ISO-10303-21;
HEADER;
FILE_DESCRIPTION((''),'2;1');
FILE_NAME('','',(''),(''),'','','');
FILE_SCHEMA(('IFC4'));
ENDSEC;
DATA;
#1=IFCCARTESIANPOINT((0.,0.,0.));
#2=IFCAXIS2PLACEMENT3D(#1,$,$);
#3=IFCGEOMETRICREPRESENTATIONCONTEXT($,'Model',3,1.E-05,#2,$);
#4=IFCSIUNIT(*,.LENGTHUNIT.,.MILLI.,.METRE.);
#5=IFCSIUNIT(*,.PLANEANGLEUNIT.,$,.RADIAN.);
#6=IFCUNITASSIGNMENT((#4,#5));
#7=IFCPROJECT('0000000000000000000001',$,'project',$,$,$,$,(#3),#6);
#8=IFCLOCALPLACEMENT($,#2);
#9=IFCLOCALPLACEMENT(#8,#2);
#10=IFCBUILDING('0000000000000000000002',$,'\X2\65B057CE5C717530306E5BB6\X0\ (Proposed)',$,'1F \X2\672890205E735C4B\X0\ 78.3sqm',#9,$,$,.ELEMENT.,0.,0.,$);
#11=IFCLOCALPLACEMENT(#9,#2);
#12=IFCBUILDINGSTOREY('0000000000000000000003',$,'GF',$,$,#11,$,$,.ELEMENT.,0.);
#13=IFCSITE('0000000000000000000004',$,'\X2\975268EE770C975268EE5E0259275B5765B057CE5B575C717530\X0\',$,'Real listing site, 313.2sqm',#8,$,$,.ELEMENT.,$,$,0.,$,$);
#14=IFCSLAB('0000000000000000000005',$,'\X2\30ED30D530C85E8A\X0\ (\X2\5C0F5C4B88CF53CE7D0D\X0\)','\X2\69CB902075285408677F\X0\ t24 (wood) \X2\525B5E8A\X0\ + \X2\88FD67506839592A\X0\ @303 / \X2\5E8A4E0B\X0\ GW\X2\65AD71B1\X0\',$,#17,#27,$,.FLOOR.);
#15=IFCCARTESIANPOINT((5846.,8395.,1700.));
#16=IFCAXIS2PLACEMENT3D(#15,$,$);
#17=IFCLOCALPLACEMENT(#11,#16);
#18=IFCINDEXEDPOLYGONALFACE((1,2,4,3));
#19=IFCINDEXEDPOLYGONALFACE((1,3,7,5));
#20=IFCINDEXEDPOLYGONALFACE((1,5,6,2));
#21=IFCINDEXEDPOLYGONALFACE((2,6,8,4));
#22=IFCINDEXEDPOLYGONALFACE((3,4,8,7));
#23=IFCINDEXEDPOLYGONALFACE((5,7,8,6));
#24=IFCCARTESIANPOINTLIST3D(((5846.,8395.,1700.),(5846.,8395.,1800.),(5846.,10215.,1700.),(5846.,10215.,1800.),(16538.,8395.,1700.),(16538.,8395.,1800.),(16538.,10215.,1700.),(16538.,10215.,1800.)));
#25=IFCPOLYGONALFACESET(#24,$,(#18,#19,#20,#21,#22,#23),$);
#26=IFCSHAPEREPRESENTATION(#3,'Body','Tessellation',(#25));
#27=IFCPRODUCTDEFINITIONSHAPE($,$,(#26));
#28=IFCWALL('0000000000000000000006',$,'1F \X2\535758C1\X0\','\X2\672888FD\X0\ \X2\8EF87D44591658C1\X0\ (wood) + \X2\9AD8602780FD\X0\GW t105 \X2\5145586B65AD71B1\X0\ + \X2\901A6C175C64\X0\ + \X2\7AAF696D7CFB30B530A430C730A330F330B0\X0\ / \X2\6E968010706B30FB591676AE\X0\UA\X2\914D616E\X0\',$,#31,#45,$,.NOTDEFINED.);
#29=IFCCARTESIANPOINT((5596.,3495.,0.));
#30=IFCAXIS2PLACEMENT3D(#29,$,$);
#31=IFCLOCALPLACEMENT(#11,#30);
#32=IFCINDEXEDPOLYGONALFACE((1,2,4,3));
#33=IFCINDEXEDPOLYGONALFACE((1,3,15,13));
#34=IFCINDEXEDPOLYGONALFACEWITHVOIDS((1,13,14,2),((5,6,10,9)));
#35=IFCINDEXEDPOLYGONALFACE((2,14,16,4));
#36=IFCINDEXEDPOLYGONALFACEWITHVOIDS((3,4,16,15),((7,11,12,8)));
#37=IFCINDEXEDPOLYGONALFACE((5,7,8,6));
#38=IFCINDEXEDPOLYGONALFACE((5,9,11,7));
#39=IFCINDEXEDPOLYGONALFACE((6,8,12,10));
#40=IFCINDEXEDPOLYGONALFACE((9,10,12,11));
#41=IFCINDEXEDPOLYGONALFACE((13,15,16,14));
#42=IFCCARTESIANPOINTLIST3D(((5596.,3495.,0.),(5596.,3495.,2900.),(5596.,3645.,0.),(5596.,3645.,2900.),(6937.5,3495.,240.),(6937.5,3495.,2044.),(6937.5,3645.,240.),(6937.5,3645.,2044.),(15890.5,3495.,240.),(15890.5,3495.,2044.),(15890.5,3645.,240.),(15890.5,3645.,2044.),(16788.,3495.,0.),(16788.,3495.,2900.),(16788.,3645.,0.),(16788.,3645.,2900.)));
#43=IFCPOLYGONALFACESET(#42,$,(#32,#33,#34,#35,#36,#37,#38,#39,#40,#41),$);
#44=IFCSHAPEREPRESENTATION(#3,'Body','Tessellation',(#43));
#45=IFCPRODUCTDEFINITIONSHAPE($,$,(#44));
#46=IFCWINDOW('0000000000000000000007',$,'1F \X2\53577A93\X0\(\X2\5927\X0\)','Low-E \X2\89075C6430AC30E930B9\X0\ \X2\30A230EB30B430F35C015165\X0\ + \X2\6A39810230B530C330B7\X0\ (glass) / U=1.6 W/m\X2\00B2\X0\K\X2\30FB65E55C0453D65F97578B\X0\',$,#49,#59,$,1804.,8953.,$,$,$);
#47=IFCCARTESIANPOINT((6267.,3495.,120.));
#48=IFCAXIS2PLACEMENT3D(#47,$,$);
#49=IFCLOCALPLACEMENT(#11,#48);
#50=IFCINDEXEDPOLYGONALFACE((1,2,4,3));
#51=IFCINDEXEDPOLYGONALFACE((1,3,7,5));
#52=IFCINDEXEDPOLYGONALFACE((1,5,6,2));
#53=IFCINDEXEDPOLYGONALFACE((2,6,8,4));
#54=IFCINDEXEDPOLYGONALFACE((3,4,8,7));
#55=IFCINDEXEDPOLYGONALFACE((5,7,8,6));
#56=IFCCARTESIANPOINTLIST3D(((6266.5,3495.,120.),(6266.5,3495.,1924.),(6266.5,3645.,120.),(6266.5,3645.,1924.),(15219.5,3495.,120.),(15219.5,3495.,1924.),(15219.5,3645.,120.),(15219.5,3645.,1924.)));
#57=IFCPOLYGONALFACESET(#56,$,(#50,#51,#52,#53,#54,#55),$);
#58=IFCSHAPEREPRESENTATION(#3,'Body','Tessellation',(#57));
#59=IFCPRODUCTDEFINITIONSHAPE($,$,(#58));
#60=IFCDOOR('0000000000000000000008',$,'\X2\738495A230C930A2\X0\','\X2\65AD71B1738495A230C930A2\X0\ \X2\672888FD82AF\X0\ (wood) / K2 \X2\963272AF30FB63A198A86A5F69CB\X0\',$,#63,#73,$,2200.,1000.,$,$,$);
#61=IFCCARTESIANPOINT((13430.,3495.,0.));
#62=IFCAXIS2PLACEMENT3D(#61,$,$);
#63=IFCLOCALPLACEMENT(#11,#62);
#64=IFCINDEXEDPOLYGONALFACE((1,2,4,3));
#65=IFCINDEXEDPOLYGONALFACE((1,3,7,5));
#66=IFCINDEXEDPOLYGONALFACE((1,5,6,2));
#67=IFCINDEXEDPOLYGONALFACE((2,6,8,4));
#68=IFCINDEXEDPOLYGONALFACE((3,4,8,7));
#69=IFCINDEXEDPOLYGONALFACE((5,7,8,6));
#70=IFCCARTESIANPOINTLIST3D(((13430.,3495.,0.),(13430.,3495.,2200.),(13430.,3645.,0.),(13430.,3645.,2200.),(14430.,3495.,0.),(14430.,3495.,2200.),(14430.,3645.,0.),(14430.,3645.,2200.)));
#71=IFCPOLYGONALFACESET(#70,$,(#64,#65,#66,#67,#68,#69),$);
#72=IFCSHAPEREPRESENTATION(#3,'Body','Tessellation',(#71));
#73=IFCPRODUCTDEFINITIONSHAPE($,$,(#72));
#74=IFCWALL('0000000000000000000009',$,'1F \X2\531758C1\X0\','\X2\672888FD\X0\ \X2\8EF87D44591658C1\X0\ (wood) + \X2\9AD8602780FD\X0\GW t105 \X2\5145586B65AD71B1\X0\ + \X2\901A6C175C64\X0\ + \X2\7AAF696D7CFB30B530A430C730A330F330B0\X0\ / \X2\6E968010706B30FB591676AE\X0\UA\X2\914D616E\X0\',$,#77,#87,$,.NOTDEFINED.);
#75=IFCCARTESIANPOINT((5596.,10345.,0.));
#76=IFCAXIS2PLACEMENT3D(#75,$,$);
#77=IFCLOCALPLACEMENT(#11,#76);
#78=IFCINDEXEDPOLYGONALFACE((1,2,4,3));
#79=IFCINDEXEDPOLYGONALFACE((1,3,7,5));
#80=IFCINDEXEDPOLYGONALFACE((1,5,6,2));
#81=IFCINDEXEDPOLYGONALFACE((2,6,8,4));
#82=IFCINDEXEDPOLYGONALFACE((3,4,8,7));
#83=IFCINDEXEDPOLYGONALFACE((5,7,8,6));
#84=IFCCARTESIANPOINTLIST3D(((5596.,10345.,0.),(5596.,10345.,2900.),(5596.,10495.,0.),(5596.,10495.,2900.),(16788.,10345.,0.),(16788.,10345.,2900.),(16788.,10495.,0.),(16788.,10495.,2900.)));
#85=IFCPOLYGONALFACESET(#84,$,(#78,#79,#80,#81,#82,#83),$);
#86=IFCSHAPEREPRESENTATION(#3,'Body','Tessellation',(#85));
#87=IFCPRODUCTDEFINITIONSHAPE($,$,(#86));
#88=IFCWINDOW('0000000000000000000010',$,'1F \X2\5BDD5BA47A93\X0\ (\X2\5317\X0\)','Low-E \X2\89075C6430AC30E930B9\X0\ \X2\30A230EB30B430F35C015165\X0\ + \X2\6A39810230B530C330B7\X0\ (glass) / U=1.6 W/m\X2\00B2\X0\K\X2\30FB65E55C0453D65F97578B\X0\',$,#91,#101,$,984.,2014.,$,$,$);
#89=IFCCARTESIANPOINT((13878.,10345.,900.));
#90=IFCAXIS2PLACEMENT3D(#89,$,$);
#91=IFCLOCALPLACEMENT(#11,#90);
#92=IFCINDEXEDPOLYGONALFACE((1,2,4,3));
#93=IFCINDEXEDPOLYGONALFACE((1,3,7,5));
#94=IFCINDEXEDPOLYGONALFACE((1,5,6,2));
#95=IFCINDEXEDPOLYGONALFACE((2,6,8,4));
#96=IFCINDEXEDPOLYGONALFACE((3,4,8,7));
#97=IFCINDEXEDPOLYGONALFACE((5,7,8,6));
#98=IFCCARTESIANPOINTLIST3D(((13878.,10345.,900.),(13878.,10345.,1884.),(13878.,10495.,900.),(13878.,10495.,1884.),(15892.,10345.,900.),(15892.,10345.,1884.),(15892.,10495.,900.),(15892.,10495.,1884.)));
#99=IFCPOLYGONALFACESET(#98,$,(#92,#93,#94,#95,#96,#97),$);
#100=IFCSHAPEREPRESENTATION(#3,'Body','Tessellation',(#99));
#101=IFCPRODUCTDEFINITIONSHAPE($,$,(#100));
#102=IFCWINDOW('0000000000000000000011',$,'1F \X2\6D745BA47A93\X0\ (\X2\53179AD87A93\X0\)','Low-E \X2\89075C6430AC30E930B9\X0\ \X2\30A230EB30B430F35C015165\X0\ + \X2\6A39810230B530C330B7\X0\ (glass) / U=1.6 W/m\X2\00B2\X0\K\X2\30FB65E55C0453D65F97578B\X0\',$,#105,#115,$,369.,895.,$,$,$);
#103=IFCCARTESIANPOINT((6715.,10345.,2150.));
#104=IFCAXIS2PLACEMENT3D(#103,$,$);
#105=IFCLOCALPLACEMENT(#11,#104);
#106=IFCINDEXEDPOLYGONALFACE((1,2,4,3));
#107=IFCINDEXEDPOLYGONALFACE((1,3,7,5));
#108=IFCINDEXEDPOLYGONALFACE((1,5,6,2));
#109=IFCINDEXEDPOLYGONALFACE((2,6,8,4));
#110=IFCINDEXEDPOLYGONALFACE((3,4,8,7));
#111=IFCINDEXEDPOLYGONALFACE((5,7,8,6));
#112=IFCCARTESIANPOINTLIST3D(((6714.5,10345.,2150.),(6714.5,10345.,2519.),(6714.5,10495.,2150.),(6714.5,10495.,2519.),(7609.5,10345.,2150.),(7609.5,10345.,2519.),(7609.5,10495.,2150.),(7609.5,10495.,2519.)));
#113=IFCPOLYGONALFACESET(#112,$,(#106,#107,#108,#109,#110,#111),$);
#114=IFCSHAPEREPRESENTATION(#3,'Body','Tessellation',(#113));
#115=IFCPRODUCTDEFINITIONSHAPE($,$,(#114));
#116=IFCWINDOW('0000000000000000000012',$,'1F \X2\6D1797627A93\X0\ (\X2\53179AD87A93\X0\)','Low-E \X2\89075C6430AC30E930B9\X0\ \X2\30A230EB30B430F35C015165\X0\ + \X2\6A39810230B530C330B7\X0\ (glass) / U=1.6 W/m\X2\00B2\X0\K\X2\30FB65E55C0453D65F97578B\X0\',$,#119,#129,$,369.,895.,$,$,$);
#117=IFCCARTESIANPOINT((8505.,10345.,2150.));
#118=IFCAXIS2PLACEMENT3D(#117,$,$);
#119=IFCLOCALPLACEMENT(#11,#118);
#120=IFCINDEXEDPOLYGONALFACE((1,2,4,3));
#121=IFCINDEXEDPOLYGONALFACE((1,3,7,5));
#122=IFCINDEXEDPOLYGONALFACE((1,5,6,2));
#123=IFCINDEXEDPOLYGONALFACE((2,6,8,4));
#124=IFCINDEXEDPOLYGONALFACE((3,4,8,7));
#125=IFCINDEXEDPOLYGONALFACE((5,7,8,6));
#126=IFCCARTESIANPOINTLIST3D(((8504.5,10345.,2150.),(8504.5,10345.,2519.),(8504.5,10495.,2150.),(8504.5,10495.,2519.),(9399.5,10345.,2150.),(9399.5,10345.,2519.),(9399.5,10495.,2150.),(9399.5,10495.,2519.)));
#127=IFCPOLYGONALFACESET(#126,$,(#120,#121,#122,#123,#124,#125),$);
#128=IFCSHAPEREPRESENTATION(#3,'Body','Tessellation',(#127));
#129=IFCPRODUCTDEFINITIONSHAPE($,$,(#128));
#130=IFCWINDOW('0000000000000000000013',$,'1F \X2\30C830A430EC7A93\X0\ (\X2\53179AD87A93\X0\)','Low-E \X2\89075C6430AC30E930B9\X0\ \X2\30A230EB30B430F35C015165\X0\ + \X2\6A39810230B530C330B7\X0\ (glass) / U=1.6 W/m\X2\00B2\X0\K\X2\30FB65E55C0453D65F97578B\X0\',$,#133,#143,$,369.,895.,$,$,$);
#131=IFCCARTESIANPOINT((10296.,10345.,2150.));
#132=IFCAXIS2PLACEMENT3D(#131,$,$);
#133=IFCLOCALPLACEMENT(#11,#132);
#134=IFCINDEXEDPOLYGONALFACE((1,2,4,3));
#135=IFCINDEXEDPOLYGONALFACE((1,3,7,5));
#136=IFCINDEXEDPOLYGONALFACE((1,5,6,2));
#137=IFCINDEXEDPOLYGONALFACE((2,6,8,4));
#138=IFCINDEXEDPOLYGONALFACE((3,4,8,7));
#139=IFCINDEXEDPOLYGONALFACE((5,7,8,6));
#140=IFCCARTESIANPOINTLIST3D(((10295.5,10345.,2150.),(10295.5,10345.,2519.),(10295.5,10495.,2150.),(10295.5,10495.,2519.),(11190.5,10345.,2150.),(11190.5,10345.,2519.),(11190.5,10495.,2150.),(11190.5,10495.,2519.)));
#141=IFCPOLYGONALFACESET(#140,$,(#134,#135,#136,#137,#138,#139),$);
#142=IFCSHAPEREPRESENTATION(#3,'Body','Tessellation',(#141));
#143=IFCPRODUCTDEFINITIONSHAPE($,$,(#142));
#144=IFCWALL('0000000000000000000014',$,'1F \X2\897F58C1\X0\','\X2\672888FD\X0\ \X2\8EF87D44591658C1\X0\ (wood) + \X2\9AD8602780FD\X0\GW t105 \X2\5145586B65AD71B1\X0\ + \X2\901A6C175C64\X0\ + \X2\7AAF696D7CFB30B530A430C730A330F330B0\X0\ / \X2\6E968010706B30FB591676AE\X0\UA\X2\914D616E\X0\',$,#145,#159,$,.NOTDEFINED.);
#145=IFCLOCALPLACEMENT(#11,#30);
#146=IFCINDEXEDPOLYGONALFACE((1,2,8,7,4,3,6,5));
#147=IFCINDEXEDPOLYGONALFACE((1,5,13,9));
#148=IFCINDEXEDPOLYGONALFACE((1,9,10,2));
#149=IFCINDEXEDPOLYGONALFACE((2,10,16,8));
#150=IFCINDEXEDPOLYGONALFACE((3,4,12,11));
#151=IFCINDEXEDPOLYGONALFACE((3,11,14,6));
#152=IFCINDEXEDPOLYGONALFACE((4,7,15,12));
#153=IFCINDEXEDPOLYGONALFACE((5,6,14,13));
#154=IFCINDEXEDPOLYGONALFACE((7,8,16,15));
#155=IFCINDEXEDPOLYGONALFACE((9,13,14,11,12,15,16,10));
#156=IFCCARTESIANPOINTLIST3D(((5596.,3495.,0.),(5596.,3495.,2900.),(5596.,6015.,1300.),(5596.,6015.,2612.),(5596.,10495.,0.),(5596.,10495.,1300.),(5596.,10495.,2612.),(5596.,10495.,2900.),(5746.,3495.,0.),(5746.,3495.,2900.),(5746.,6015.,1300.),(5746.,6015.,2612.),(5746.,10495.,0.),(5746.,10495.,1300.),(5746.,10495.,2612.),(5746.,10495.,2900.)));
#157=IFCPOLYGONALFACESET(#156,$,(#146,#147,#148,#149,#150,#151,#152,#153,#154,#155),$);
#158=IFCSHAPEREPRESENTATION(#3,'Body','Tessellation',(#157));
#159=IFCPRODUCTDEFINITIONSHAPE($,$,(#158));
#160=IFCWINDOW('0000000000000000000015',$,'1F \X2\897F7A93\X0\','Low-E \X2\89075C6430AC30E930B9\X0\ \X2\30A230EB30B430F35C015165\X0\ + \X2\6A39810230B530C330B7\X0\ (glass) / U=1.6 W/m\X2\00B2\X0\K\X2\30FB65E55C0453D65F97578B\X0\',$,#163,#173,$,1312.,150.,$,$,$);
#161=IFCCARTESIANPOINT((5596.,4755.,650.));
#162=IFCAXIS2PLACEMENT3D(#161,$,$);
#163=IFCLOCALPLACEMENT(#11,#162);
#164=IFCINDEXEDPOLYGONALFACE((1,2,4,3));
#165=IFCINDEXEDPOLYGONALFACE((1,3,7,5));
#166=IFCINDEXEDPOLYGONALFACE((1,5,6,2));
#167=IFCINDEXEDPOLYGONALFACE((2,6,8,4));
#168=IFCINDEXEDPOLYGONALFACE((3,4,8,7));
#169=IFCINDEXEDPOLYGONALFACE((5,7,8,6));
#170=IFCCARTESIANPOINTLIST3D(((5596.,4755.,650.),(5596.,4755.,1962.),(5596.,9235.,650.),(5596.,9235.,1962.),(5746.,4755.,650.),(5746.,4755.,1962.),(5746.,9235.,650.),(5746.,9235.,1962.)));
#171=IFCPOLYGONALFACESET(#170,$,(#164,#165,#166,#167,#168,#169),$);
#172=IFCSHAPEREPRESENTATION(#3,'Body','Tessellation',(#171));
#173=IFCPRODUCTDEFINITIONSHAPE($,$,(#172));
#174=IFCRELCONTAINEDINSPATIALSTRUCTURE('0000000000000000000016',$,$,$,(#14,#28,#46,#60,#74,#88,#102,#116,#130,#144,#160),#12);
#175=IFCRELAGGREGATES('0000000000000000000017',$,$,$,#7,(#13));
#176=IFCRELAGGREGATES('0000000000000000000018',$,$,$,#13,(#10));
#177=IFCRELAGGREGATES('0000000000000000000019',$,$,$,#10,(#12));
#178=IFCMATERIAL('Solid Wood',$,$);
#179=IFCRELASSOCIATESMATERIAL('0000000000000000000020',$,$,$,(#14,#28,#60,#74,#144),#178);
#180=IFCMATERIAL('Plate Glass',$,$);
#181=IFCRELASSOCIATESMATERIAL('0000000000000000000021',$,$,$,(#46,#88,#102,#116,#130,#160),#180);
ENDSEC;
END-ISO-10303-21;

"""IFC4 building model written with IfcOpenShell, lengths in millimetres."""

from ifc_helpers import new_model, si_unit, frame, frame_2d, origin, place, context, project, spatial, rectangle, extrude, material, element, fill, save


model = new_model("IFC4")

# Units and contexts
model_context = context("Model", 3, precision=1e-05, world=origin())
ifc_project = project(units=[si_unit("LENGTHUNIT", "METRE", prefix="MILLI"), si_unit("PLANEANGLEUNIT", "RADIAN")], contexts=[model_context])

# Site, building, storey
site_placement = place(None, origin())
site = spatial("IfcSite", under=ifc_project, at=site_placement, Name="青森県青森市大字新城字山田", ObjectType="Real listing site, 313.2sqm", CompositionType="ELEMENT", RefElevation=0.0)
building_placement = place(site_placement, origin())
building = spatial("IfcBuilding", under=site, at=building_placement, Name="新城山田の家 (Proposed)", ObjectType="1F 木造平屋 78.3sqm", CompositionType="ELEMENT", ElevationOfRefHeight=0.0, ElevationOfTerrain=0.0)
storey_placement = place(building_placement, origin())
storey = spatial("IfcBuildingStorey", under=building, at=storey_placement, Name="GF", CompositionType="ELEMENT", Elevation=0.0)

# Slab
ifc_material_1 = material(Name="Solid Wood")
slab_1_placement = place(storey_placement, frame((5846.0, 8395.0, 1700.0)))
element("IfcSlab", 1, at=slab_1_placement, inside=storey, material=ifc_material_1, Name="ロフト床 (小屋裏収納)", Description="構造用合板 t24 (wood) 剛床 + 製材根太 @303 / 床下 GW断熱", PredefinedType="FLOOR", context=model_context, shape_type="SweptSolid", body=[
    extrude(rectangle(XDim=10692.0, YDim=1820.0, at=frame_2d((5346.0, 910.0))), frame((5846.0, 8395.0, 1700.0)), (0.0, 0.0, 1.0), 100.0),
])

# Wall, openings, window, door
wall_1_placement = place(storey_placement, frame((5596.0, 3495.0, 0.0)))
wall_1 = element("IfcWall", 2, at=wall_1_placement, inside=storey, material=ifc_material_1, Name="1F 南壁", Description="木製 軸組外壁 (wood) + 高性能GW t105 充填断熱 + 通気層 + 窯業系サイディング / 準耐火・外皮UA配慮", PredefinedType="NOTDEFINED", context=model_context, shape_type="SweptSolid", body=[
    extrude(rectangle(XDim=11192.0, YDim=150.0, at=frame_2d((5596.0, 75.0))), frame((5596.0, 3495.0, 0.0)), (0.0, 0.0, 1.0), 2900.0),
])
opening_1_placement = place(storey_placement, frame((6267.0, 3495.0, 120.0)))
opening_1 = element("IfcOpeningElement", 3, at=opening_1_placement, cuts=wall_1, PredefinedType="NOTDEFINED", context=model_context, shape_type="SweptSolid", body=[
    extrude(rectangle(XDim=8953.0, YDim=150.0, at=frame_2d((4476.0, 75.0))), frame((6267.0, 3495.0, 120.0)), (0.0, 0.0, 1.0), 1804.0),
])
opening_2_placement = place(storey_placement, frame((13430.0, 3495.0, 0.0)))
opening_2 = element("IfcOpeningElement", 4, at=opening_2_placement, cuts=wall_1, PredefinedType="NOTDEFINED", context=model_context, shape_type="SweptSolid", body=[
    extrude(rectangle(XDim=1000.0, YDim=150.0, at=frame_2d((500.0, 75.0))), frame((13430.0, 3495.0, 0.0)), (0.0, 0.0, 1.0), 2200.0),
])
ifc_material_2 = material(Name="Plate Glass")
window_1_placement = place(storey_placement, frame((6267.0, 3495.0, 120.0)))
window_1 = element("IfcWindow", 5, at=window_1_placement, inside=storey, material=ifc_material_2, Name="1F 南窓(大)", Description="Low-E 複層ガラス アルゴン封入 + 樹脂サッシ (glass) / U=1.6 W/m²K・日射取得型", OverallHeight=1804.0, OverallWidth=8953.0, context=model_context, shape_type="SweptSolid", body=[
    extrude(rectangle(XDim=8953.0, YDim=150.0, at=frame_2d((4476.0, 75.0))), frame((6267.0, 3495.0, 120.0)), (0.0, 0.0, 1.0), 1804.0),
])
fill(opening_1, window_1)
door_1_placement = place(storey_placement, frame((13430.0, 3495.0, 0.0)))
door_1 = element("IfcDoor", 6, at=door_1_placement, inside=storey, material=ifc_material_1, Name="玄関ドア", Description="断熱玄関ドア 木製芯 (wood) / K2 防犯・採風機構", OverallHeight=2200.0, OverallWidth=1000.0, context=model_context, shape_type="SweptSolid", body=[
    extrude(rectangle(XDim=1000.0, YDim=150.0, at=frame_2d((500.0, 75.0))), frame((13430.0, 3495.0, 0.0)), (0.0, 0.0, 1.0), 2200.0),
])
fill(opening_2, door_1)

# Wall, openings, windows
wall_2_placement = place(storey_placement, frame((5596.0, 10345.0, 0.0)))
wall_2 = element("IfcWall", 7, at=wall_2_placement, inside=storey, material=ifc_material_1, Name="1F 北壁", Description="木製 軸組外壁 (wood) + 高性能GW t105 充填断熱 + 通気層 + 窯業系サイディング / 準耐火・外皮UA配慮", PredefinedType="NOTDEFINED", context=model_context, shape_type="SweptSolid", body=[
    extrude(rectangle(XDim=11192.0, YDim=150.0, at=frame_2d((5596.0, 75.0))), frame((5596.0, 10345.0, 0.0)), (0.0, 0.0, 1.0), 2900.0),
])
opening_3_placement = place(storey_placement, frame((13878.0, 10345.0, 900.0)))
opening_3 = element("IfcOpeningElement", 8, at=opening_3_placement, cuts=wall_2, PredefinedType="NOTDEFINED", context=model_context, shape_type="SweptSolid", body=[
    extrude(rectangle(XDim=2014.0, YDim=150.0, at=frame_2d((1007.0, 75.0))), frame((13878.0, 10345.0, 900.0)), (0.0, 0.0, 1.0), 984.0),
])
opening_4_placement = place(storey_placement, frame((6715.0, 10345.0, 2150.0)))
opening_4 = element("IfcOpeningElement", 9, at=opening_4_placement, cuts=wall_2, PredefinedType="NOTDEFINED", context=model_context, shape_type="SweptSolid", body=[
    extrude(rectangle(XDim=895.0, YDim=150.0, at=frame_2d((447.0, 75.0))), frame((6715.0, 10345.0, 2150.0)), (0.0, 0.0, 1.0), 369.0),
])
opening_5_placement = place(storey_placement, frame((8505.0, 10345.0, 2150.0)))
opening_5 = element("IfcOpeningElement", 10, at=opening_5_placement, cuts=wall_2, PredefinedType="NOTDEFINED", context=model_context, shape_type="SweptSolid", body=[
    extrude(rectangle(XDim=895.0, YDim=150.0, at=frame_2d((447.0, 75.0))), frame((8505.0, 10345.0, 2150.0)), (0.0, 0.0, 1.0), 369.0),
])
opening_6_placement = place(storey_placement, frame((10296.0, 10345.0, 2150.0)))
opening_6 = element("IfcOpeningElement", 11, at=opening_6_placement, cuts=wall_2, PredefinedType="NOTDEFINED", context=model_context, shape_type="SweptSolid", body=[
    extrude(rectangle(XDim=895.0, YDim=150.0, at=frame_2d((447.0, 75.0))), frame((10296.0, 10345.0, 2150.0)), (0.0, 0.0, 1.0), 369.0),
])
window_2_placement = place(storey_placement, frame((13878.0, 10345.0, 900.0)))
window_2 = element("IfcWindow", 12, at=window_2_placement, inside=storey, material=ifc_material_2, Name="1F 寝室窓 (北)", Description="Low-E 複層ガラス アルゴン封入 + 樹脂サッシ (glass) / U=1.6 W/m²K・日射取得型", OverallHeight=984.0, OverallWidth=2014.0, context=model_context, shape_type="SweptSolid", body=[
    extrude(rectangle(XDim=2014.0, YDim=150.0, at=frame_2d((1007.0, 75.0))), frame((13878.0, 10345.0, 900.0)), (0.0, 0.0, 1.0), 984.0),
])
fill(opening_3, window_2)
window_3_placement = place(storey_placement, frame((6715.0, 10345.0, 2150.0)))
window_3 = element("IfcWindow", 13, at=window_3_placement, inside=storey, material=ifc_material_2, Name="1F 浴室窓 (北高窓)", Description="Low-E 複層ガラス アルゴン封入 + 樹脂サッシ (glass) / U=1.6 W/m²K・日射取得型", OverallHeight=369.0, OverallWidth=895.0, context=model_context, shape_type="SweptSolid", body=[
    extrude(rectangle(XDim=895.0, YDim=150.0, at=frame_2d((447.0, 75.0))), frame((6715.0, 10345.0, 2150.0)), (0.0, 0.0, 1.0), 369.0),
])
fill(opening_4, window_3)
window_4_placement = place(storey_placement, frame((8505.0, 10345.0, 2150.0)))
window_4 = element("IfcWindow", 14, at=window_4_placement, inside=storey, material=ifc_material_2, Name="1F 洗面窓 (北高窓)", Description="Low-E 複層ガラス アルゴン封入 + 樹脂サッシ (glass) / U=1.6 W/m²K・日射取得型", OverallHeight=369.0, OverallWidth=895.0, context=model_context, shape_type="SweptSolid", body=[
    extrude(rectangle(XDim=895.0, YDim=150.0, at=frame_2d((447.0, 75.0))), frame((8505.0, 10345.0, 2150.0)), (0.0, 0.0, 1.0), 369.0),
])
fill(opening_5, window_4)
window_5_placement = place(storey_placement, frame((10296.0, 10345.0, 2150.0)))
window_5 = element("IfcWindow", 15, at=window_5_placement, inside=storey, material=ifc_material_2, Name="1F トイレ窓 (北高窓)", Description="Low-E 複層ガラス アルゴン封入 + 樹脂サッシ (glass) / U=1.6 W/m²K・日射取得型", OverallHeight=369.0, OverallWidth=895.0, context=model_context, shape_type="SweptSolid", body=[
    extrude(rectangle(XDim=895.0, YDim=150.0, at=frame_2d((447.0, 75.0))), frame((10296.0, 10345.0, 2150.0)), (0.0, 0.0, 1.0), 369.0),
])
fill(opening_6, window_5)

# Wall, opening, window
wall_3_placement = place(storey_placement, frame((5596.0, 3495.0, 0.0)))
wall_3 = element("IfcWall", 16, at=wall_3_placement, inside=storey, material=ifc_material_1, Name="1F 西壁", Description="木製 軸組外壁 (wood) + 高性能GW t105 充填断熱 + 通気層 + 窯業系サイディング / 準耐火・外皮UA配慮", PredefinedType="NOTDEFINED", context=model_context, shape_type="SweptSolid", body=[
    extrude(rectangle(XDim=150.0, YDim=7000.0, at=frame_2d((75.0, 3500.0))), frame((5596.0, 3495.0, 0.0)), (0.0, 0.0, 1.0), 2900.0),
])
opening_7_placement = place(storey_placement, frame((5596.0, 4755.0, 650.0)))
opening_7 = element("IfcOpeningElement", 17, at=opening_7_placement, cuts=wall_3, PredefinedType="NOTDEFINED", context=model_context, shape_type="SweptSolid", body=[
    extrude(rectangle(XDim=150.0, YDim=4480.0, at=frame_2d((75.0, 2240.0))), frame((5596.0, 4755.0, 650.0)), (0.0, 0.0, 1.0), 1312.0),
])
window_6_placement = place(storey_placement, frame((5596.0, 4755.0, 650.0)))
window_6 = element("IfcWindow", 18, at=window_6_placement, inside=storey, material=ifc_material_2, Name="1F 西窓", Description="Low-E 複層ガラス アルゴン封入 + 樹脂サッシ (glass) / U=1.6 W/m²K・日射取得型", OverallHeight=1312.0, OverallWidth=150.0, context=model_context, shape_type="SweptSolid", body=[
    extrude(rectangle(XDim=150.0, YDim=4480.0, at=frame_2d((75.0, 2240.0))), frame((5596.0, 4755.0, 650.0)), (0.0, 0.0, 1.0), 1312.0),
])
fill(opening_7, window_6)

save(model, "model.ifc")
